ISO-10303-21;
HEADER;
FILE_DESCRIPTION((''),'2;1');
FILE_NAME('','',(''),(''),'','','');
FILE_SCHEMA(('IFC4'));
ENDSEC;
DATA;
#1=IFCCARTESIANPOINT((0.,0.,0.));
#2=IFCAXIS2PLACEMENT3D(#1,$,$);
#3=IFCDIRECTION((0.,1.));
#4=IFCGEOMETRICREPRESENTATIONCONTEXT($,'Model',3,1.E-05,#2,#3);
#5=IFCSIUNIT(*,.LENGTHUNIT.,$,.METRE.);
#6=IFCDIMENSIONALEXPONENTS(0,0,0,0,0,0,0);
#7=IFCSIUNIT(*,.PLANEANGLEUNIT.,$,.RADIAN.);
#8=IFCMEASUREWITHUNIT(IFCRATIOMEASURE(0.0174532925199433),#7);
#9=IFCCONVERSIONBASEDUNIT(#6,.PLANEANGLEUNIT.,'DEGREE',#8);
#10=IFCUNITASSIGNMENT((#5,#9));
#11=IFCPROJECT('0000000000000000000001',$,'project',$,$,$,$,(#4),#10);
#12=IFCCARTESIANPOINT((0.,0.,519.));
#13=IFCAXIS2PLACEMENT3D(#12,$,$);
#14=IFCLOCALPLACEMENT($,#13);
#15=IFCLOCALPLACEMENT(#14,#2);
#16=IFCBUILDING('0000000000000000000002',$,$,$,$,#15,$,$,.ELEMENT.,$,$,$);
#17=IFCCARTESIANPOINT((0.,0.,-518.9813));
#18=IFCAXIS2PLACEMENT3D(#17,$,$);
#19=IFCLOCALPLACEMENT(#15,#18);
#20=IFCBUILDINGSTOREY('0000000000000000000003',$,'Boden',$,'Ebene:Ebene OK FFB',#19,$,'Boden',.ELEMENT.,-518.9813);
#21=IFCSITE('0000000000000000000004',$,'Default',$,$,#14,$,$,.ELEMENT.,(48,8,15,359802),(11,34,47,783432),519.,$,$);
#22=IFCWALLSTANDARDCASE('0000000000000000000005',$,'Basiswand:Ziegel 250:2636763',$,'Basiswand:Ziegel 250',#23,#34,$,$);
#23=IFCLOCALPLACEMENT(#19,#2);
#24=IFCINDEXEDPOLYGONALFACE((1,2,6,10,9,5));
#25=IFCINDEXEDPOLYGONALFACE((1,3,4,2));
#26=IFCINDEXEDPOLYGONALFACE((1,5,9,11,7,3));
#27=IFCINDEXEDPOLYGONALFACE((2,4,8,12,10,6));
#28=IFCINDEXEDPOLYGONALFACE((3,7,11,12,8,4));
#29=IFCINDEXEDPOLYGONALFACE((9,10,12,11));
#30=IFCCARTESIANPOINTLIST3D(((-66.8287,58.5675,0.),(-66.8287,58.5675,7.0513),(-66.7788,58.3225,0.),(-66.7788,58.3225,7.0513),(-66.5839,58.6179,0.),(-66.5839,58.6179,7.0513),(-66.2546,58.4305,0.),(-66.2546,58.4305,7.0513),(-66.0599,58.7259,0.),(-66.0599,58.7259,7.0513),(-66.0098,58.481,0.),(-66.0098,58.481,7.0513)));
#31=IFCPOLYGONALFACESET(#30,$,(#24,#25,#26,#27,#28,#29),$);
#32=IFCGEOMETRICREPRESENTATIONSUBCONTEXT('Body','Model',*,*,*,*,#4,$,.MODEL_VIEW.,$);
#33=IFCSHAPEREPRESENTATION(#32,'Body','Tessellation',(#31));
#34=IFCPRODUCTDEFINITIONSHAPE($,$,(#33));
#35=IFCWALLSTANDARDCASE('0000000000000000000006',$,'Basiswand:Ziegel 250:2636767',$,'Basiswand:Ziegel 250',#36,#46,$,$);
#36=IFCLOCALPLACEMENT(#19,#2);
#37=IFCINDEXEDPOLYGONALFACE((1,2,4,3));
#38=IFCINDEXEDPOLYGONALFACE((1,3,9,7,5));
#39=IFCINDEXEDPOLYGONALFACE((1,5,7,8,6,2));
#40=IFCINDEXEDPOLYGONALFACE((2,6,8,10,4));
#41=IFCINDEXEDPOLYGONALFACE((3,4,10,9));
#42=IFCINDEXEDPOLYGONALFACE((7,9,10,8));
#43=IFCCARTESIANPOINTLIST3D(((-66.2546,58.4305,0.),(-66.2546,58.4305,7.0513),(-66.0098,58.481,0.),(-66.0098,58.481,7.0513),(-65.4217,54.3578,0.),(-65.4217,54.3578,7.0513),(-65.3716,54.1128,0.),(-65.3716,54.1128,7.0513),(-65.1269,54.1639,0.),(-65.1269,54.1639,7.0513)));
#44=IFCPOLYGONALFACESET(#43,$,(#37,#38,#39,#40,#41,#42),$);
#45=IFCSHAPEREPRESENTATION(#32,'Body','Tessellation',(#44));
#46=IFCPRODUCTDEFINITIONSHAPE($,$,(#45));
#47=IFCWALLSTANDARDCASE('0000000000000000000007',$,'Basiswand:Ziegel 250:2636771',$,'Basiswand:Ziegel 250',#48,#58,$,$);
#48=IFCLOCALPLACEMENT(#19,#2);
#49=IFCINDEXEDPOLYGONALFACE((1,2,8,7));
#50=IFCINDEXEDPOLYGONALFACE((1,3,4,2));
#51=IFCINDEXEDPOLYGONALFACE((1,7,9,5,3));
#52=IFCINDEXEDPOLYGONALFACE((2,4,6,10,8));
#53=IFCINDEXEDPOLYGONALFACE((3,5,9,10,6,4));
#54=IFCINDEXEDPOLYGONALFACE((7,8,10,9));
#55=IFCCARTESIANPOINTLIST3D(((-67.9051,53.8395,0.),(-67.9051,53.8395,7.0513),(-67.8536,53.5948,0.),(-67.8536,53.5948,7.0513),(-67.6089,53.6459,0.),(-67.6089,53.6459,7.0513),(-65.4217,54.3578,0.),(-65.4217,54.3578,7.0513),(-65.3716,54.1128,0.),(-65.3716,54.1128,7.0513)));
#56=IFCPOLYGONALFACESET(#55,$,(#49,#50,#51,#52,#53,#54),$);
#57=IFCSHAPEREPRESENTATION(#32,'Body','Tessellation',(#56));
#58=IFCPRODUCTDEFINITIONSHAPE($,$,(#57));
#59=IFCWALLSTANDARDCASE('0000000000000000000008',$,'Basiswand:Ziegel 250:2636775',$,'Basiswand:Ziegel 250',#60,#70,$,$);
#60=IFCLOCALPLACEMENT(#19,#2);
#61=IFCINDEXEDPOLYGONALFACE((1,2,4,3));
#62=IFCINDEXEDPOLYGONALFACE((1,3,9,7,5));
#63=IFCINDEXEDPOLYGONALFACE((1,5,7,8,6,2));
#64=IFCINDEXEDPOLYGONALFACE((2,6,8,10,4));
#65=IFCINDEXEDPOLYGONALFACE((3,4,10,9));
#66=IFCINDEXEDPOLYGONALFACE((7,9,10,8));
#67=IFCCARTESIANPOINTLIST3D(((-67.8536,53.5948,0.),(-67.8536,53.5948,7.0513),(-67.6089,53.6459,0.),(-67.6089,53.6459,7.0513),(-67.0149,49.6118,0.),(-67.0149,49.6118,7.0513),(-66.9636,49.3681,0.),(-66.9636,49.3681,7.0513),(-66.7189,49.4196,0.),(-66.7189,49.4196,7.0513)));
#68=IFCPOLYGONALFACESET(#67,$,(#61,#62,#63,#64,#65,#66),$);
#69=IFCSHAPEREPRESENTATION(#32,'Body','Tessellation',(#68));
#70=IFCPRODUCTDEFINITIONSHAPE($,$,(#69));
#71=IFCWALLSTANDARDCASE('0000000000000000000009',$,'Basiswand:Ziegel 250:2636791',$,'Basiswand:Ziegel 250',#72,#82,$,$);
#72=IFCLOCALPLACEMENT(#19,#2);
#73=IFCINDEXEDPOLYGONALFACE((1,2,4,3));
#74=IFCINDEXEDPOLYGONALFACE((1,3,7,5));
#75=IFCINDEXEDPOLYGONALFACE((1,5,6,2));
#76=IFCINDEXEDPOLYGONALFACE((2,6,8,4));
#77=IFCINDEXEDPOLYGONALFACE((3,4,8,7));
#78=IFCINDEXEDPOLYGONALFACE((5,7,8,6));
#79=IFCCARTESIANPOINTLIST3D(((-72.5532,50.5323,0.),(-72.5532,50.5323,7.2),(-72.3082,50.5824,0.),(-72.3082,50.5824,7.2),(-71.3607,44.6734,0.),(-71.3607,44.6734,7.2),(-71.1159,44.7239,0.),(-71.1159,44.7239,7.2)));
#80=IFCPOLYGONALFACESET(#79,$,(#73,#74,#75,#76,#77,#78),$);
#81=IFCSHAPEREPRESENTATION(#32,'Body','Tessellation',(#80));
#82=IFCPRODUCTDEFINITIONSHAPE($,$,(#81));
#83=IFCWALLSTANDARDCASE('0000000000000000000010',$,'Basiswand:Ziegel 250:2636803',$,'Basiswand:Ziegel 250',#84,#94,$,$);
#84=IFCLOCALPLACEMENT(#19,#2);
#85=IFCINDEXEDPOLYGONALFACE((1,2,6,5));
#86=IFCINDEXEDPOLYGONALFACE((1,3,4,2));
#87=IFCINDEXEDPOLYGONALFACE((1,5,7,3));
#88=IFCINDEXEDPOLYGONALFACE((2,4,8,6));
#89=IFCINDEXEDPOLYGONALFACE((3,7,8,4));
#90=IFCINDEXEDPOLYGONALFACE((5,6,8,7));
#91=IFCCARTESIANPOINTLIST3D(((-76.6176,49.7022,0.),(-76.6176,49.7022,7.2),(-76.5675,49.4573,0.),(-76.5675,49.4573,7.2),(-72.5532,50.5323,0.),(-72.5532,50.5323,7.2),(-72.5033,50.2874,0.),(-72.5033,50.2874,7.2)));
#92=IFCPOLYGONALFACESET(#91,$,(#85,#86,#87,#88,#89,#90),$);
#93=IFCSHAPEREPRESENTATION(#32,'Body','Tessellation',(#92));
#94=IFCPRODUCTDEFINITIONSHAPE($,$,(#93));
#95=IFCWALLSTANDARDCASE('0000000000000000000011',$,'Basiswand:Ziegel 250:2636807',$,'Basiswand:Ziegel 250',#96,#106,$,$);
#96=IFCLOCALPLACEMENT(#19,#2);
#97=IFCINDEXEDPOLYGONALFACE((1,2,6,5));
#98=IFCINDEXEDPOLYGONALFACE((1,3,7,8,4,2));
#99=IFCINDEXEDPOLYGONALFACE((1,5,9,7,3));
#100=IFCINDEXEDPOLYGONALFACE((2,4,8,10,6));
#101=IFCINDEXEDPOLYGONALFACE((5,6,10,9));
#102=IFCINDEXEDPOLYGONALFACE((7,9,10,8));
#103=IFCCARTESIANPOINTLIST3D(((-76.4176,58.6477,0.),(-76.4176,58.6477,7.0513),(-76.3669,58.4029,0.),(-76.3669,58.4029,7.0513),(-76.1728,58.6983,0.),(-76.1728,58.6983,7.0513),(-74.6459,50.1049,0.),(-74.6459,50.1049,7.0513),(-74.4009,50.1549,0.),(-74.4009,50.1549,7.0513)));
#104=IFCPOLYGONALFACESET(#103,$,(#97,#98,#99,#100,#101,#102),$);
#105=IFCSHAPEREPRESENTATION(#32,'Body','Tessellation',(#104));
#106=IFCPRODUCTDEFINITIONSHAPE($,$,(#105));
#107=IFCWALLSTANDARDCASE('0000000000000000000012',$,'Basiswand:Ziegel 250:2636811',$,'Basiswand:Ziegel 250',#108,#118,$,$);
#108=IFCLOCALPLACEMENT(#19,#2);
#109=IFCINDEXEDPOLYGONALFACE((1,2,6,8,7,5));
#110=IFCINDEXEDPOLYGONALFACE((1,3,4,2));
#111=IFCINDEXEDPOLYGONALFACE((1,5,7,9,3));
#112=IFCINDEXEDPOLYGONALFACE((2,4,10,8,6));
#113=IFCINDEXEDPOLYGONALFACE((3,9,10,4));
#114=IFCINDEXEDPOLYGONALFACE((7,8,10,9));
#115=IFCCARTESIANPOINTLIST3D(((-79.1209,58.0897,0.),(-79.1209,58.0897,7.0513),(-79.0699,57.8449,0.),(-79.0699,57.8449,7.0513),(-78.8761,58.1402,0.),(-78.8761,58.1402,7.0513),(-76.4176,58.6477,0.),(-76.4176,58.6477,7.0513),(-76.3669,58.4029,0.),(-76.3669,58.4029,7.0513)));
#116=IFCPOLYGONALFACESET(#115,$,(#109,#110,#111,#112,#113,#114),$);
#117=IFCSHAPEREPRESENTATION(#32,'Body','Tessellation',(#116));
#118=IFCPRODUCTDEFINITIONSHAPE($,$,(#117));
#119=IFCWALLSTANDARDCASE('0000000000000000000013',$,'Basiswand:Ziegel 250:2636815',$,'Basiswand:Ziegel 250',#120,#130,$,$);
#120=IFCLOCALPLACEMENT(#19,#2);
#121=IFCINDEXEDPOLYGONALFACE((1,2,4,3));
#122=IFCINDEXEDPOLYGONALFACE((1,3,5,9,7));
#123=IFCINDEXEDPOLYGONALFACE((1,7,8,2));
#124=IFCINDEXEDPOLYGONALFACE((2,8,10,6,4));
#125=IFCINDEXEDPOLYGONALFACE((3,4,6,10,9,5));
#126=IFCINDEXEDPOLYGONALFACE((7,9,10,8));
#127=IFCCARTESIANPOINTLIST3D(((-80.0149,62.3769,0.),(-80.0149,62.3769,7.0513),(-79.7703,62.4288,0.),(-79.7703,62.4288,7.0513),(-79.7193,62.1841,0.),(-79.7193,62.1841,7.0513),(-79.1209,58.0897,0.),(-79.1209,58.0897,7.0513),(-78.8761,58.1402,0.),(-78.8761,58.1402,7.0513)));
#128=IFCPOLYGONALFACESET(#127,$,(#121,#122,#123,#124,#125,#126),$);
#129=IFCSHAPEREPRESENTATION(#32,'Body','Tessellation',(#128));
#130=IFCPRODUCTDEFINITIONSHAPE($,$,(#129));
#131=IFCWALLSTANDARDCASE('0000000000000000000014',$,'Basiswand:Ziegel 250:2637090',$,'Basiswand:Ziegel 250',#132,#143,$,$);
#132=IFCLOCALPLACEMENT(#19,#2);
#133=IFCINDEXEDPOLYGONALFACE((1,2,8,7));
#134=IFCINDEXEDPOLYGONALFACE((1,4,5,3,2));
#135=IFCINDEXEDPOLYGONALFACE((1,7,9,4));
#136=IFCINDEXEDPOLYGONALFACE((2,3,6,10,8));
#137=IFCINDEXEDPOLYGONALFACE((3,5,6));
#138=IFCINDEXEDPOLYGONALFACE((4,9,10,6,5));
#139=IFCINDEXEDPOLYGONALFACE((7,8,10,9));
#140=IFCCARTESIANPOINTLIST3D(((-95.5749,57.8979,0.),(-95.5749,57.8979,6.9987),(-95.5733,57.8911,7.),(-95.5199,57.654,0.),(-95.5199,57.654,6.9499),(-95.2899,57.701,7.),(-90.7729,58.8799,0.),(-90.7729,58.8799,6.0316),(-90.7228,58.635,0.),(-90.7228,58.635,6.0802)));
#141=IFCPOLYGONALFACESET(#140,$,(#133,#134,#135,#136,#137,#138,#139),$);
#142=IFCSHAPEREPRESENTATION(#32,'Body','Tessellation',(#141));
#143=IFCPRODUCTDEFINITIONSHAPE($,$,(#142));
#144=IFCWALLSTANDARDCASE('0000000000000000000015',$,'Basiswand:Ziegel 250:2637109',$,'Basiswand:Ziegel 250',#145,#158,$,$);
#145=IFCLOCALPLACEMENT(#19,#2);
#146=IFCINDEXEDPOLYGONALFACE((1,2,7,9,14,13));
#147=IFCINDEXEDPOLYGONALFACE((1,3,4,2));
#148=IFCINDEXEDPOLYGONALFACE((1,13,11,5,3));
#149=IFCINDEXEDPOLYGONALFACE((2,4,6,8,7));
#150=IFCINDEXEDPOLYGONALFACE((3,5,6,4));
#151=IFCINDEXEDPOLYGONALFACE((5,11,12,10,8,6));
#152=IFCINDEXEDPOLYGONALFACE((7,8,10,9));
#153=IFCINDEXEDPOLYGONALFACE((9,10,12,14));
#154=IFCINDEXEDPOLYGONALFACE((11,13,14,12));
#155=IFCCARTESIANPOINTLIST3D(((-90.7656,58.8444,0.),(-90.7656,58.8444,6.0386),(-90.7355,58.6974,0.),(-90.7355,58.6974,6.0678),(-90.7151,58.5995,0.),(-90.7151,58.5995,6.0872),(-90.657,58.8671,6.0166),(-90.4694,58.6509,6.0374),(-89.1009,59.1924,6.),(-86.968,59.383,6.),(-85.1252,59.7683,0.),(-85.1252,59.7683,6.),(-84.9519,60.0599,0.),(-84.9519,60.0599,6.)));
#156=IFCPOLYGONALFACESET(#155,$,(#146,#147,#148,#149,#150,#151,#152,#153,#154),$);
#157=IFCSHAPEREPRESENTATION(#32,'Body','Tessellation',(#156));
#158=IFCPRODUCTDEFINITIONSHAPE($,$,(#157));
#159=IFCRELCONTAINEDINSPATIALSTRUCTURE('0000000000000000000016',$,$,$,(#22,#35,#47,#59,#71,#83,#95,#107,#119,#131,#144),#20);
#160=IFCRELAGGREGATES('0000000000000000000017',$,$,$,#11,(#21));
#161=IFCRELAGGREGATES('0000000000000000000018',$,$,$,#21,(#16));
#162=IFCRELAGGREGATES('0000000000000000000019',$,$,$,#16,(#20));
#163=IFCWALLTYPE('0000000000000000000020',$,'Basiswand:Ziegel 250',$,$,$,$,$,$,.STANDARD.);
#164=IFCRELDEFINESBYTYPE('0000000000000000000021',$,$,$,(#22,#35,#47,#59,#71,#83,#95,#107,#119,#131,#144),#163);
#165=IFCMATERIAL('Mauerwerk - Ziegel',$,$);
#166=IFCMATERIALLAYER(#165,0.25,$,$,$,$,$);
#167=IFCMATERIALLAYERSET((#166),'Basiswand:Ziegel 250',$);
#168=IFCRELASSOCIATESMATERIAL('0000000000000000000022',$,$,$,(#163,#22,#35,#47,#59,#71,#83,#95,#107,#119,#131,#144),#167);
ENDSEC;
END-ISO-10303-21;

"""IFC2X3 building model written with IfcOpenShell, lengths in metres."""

from ifc_helpers import new_model, entity, si_unit, converted_unit, direction, frame, origin, place, context, subcontext, project, spatial, polyline, outline, extrude, clip, bounded_halfspace, material, layer, layer_set, layer_usage, type_object, element, save


model = new_model("IFC2X3")

# Units and contexts
model_context = context("Model", 3, precision=1e-05, world=origin(), true_north=direction((0.0, 1.0)))
body_context = subcontext(model_context, "Body", "Model", "MODEL_VIEW")
ifc_project = project(units=[si_unit("LENGTHUNIT", "METRE"), converted_unit("PLANEANGLEUNIT", "DEGREE", entity("IfcRatioMeasure", 0.0174532925199433), si_unit("PLANEANGLEUNIT", "RADIAN"), dimensions=[0, 0, 0, 0, 0, 0, 0])], contexts=[model_context])

# Site, building, storey
site_placement = place(None, frame((0.0, 0.0, 519.0)))
site = spatial("IfcSite", under=ifc_project, at=site_placement, Name="Default", CompositionType="ELEMENT", RefLatitude=(48, 8, 15, 359802), RefLongitude=(11, 34, 47, 783432), RefElevation=519.0)
building_placement = place(site_placement, origin())
building = spatial("IfcBuilding", under=site, at=building_placement, CompositionType="ELEMENT")
storey_placement = place(building_placement, frame((0.0, 0.0, -518.9813)))
storey = spatial("IfcBuildingStorey", under=building, at=storey_placement, Name="Boden", ObjectType="Ebene:Ebene OK FFB", LongName="Boden", CompositionType="ELEMENT", Elevation=-518.9813)

# Walls
ifc_material = material(Name="Mauerwerk - Ziegel")
ifc_layer = layer(ifc_material, 0.25)
ifc_layer_set = layer_set([ifc_layer], Name="Basiswand:Ziegel 250")
ifc_layer_usage_1 = layer_usage(ifc_layer_set, "AXIS2", "NEGATIVE", 0.125)
wall_type = type_object("IfcWallType", Name="Basiswand:Ziegel 250", PredefinedType="STANDARD", material=ifc_layer_set)
wall_1_placement = place(storey_placement, frame((-66.804, 58.4449, 0.0), z_axis=(0.0, 0.0, 1.0), x_axis=(0.979414, 0.201864, 0.0)))
element("IfcWallStandardCase", 1, at=wall_1_placement, inside=storey, type_object=wall_type, material=ifc_layer_usage_1, Name="Basiswand:Ziegel 250:2636763", ObjectType="Basiswand:Ziegel 250", context=body_context, shape_type="SweptSolid", body=[
    extrude(outline(polyline([(0.7852, -0.125), (0.7856, 0.125), (0.2506, 0.125), (0.0006, 0.125), (0.0, -0.125), (0.5352, -0.125), (0.7852, -0.125)])), origin(), (0.0, 0.0, 1.0), 7.0513),
])
ifc_layer_usage_2 = layer_usage(ifc_layer_set, "AXIS2", "NEGATIVE", 0.125)
wall_2_placement = place(storey_placement, frame((-66.1322, 58.4559, 0.0), z_axis=(0.0, 0.0, 1.0), x_axis=(0.200368, -0.979721, 0.0)))
element("IfcWallStandardCase", 2, at=wall_2_placement, inside=storey, type_object=wall_type, material=ifc_layer_usage_2, Name="Basiswand:Ziegel 250:2636767", ObjectType="Basiswand:Ziegel 250", context=body_context, shape_type="SweptSolid", body=[
    extrude(outline(polyline([(4.4074, -0.125), (4.4064, 0.125), (0.0, 0.125), (0.0004, -0.125), (4.1574, -0.125), (4.4074, -0.125)])), origin(), (0.0, 0.0, 1.0), 7.0513),
])
ifc_layer_usage_3 = layer_usage(ifc_layer_set, "AXIS2", "NEGATIVE", 0.125)
wall_3_placement = place(storey_placement, frame((-65.3961, 54.2354, 0.0), z_axis=(0.0, 0.0, 1.0), x_axis=(-0.978908, -0.204301, 0.0)))
element("IfcWallStandardCase", 3, at=wall_3_placement, inside=storey, type_object=wall_type, material=ifc_layer_usage_3, Name="Basiswand:Ziegel 250:2636771", ObjectType="Basiswand:Ziegel 250", context=body_context, shape_type="SweptSolid", body=[
    extrude(outline(polyline([(2.5369, -0.125), (2.5365, 0.125), (2.2865, 0.125), (0.001, 0.125), (0.0, -0.125), (2.5369, -0.125)])), origin(), (0.0, 0.0, 1.0), 7.0513),
])
ifc_layer_usage_4 = layer_usage(ifc_layer_set, "AXIS2", "NEGATIVE", 0.125)
wall_4_placement = place(storey_placement, frame((-67.7313, 53.6206, 0.0), z_axis=(0.0, 0.0, 1.0), x_axis=(0.206048, -0.978542, 0.0)))
element("IfcWallStandardCase", 4, at=wall_4_placement, inside=storey, type_object=wall_type, material=ifc_layer_usage_4, Name="Basiswand:Ziegel 250:2636775", ObjectType="Basiswand:Ziegel 250", context=body_context, shape_type="SweptSolid", body=[
    extrude(outline(polyline([(4.3194, -0.125), (4.3194, 0.125), (0.0004, 0.125), (0.0, -0.125), (4.0704, -0.125), (4.3194, -0.125)])), origin(), (0.0, 0.0, 1.0), 7.0513),
])
ifc_layer_usage_5 = layer_usage(ifc_layer_set, "AXIS2", "NEGATIVE", 0.125)
wall_5_placement = place(storey_placement, frame((-72.4307, 50.5574, 0.0), z_axis=(0.0, 0.0, 1.0), x_axis=(0.199439, -0.97991, 0.0)))
element("IfcWallStandardCase", 5, at=wall_5_placement, inside=storey, type_object=wall_type, material=ifc_layer_usage_5, Name="Basiswand:Ziegel 250:2636791", ObjectType="Basiswand:Ziegel 250", context=body_context, shape_type="Clipping", body=[
    clip(extrude(outline(polyline([(5.9793, -0.125), (5.9786, 0.125), (2.1925, 0.125), (1.9425, 0.125), (0.0, 0.125), (0.0002, -0.125), (0.2502, -0.125), (5.7293, -0.125), (5.9793, -0.125)])), origin(), (0.0, 0.0, 1.0), 7.2), bounded_halfspace(frame((0.0002, -0.125, 7.2), z_axis=(0.0, 0.0, 1.0), x_axis=(-0.002767, 0.999996, 0.0)), False, frame((0.0002, -0.125, 7.2)), polyline([(0.0, 0.0), (0.25, 0.0), (5.7291, 0.0), (5.9791, 0.0), (5.9784, 0.25), (-0.0002, 0.25), (0.0, 0.0)]))),
])
ifc_layer_usage_6 = layer_usage(ifc_layer_set, "AXIS2", "NEGATIVE", 0.125)
wall_6_placement = place(storey_placement, frame((-76.5926, 49.5797, 0.0), z_axis=(0.0, 0.0, 1.0), x_axis=(0.979773, 0.200114, 0.0)))
element("IfcWallStandardCase", 6, at=wall_6_placement, inside=storey, type_object=wall_type, material=ifc_layer_usage_6, Name="Basiswand:Ziegel 250:2636803", ObjectType="Basiswand:Ziegel 250", context=body_context, shape_type="Clipping", body=[
    clip(extrude(outline(polyline([(4.1481, -0.125), (4.1483, 0.125), (2.2624, 0.125), (2.0124, 0.125), (0.0, 0.125), (0.0, -0.125), (4.1481, -0.125)])), origin(), (0.0, 0.0, 1.0), 7.2), bounded_halfspace(frame((0.0, -0.125, 7.2), z_axis=(0.0, 0.0, 1.0), x_axis=(0.999998, 0.002078, 0.0)), False, frame((0.0, -0.125, 7.2)), polyline([(0.0, 0.0), (4.1481, 0.0), (4.1483, 0.25), (0.0, 0.25), (0.0, 0.0)]))),
])
ifc_layer_usage_7 = layer_usage(ifc_layer_set, "AXIS2", "NEGATIVE", 0.125)
wall_7_placement = place(storey_placement, frame((-74.5233, 50.1296, 0.0), z_axis=(0.0, 0.0, 1.0), x_axis=(-0.203078, 0.979163, 0.0)))
element("IfcWallStandardCase", 7, at=wall_7_placement, inside=storey, type_object=wall_type, material=ifc_layer_usage_7, Name="Basiswand:Ziegel 250:2636807", ObjectType="Basiswand:Ziegel 250", context=body_context, shape_type="SweptSolid", body=[
    extrude(outline(polyline([(8.7251, -0.125), (8.7253, 0.125), (8.4753, 0.125), (0.0008, 0.125), (0.0, -0.125), (8.7251, -0.125)])), origin(), (0.0, 0.0, 1.0), 7.0513),
])
ifc_layer_usage_8 = layer_usage(ifc_layer_set, "AXIS2", "NEGATIVE", 0.125)
wall_8_placement = place(storey_placement, frame((-76.3921, 58.5253, 0.0), z_axis=(0.0, 0.0, 1.0), x_axis=(-0.97935, -0.202174, 0.0)))
element("IfcWallStandardCase", 8, at=wall_8_placement, inside=storey, type_object=wall_type, material=ifc_layer_usage_8, Name="Basiswand:Ziegel 250:2636811", ObjectType="Basiswand:Ziegel 250", context=body_context, shape_type="SweptSolid", body=[
    extrude(outline(polyline([(2.7605, -0.125), (2.76, 0.125), (0.0, 0.125), (0.0002, -0.125), (2.5105, -0.125), (2.7605, -0.125)])), origin(), (0.0, 0.0, 1.0), 7.0513),
])
ifc_layer_usage_9 = layer_usage(ifc_layer_set, "AXIS2", "NEGATIVE", 0.125)
wall_9_placement = place(storey_placement, frame((-78.9984, 58.1147, 0.0), z_axis=(0.0, 0.0, 1.0), x_axis=(-0.204127, 0.978944, 0.0)))
element("IfcWallStandardCase", 9, at=wall_9_placement, inside=storey, type_object=wall_type, material=ifc_layer_usage_9, Name="Basiswand:Ziegel 250:2636815", ObjectType="Basiswand:Ziegel 250", context=body_context, shape_type="SweptSolid", body=[
    extrude(outline(polyline([(4.3809, -0.125), (4.38, 0.125), (0.0005, 0.125), (0.0, -0.125), (4.1309, -0.125), (4.3809, -0.125)])), origin(), (0.0, 0.0, 1.0), 7.0513),
])
ifc_layer_usage_10 = layer_usage(ifc_layer_set, "AXIS2", "NEGATIVE", 0.125)
wall_10_placement = place(storey_placement, frame((-95.5498, 57.7755, 0.0), z_axis=(0.0, 0.0, 1.0), x_axis=(0.979724, 0.200352, 0.0)))
element("IfcWallStandardCase", 10, at=wall_10_placement, inside=storey, type_object=wall_type, material=ifc_layer_usage_10, Name="Basiswand:Ziegel 250:2637090", ObjectType="Basiswand:Ziegel 250", context=body_context, shape_type="Clipping", body=[
    clip(clip(extrude(outline(polyline([(4.9014, -0.125), (4.9014, -0.0613), (4.9014, 0.0887), (4.9014, 0.125), (0.0, 0.125), (0.005, -0.125), (0.2551, -0.125), (4.9014, -0.125)])), origin(), (0.0, 0.0, 1.0), 7.0), bounded_halfspace(frame((0.005, -0.125, 6.9499), z_axis=(-0.204536, -0.201725, 0.957848), x_axis=(0.019626, -0.979183, -0.202027)), False, frame((0.005, -0.125, 6.9499)), polyline([(0.0, 0.0), (0.2348, 0.0), (-0.0049, 0.243), (0.0, 0.0)]))), bounded_halfspace(frame((0.2398, -0.125, 7.0), z_axis=(0.190146, 0.187532, 0.963679), x_axis=(-0.981318, 0.006976, 0.192269)), False, frame((0.2398, -0.125, 7.0)), polyline([(0.0, 0.0), (0.0153, 0.0), (4.6616, 0.0), (4.6616, 0.0637), (4.6616, 0.2137), (4.6616, 0.25), (-0.2398, 0.25), (-0.2396, 0.243), (0.0, 0.0)]))),
])
ifc_layer_usage_11 = layer_usage(ifc_layer_set, "AXIS2", "NEGATIVE", 0.125)
wall_11_placement = place(storey_placement, frame((-90.7407, 58.7219, 0.0), z_axis=(0.0, 0.0, 1.0), x_axis=(0.978834, 0.204656, 0.0)))
element("IfcWallStandardCase", 11, at=wall_11_placement, inside=storey, type_object=wall_type, material=ifc_layer_usage_11, Name="Basiswand:Ziegel 250:2637109", ObjectType="Basiswand:Ziegel 250", context=body_context, shape_type="Clipping", body=[
    clip(clip(clip(clip(extrude(outline(polyline([(5.7108, -0.125), (5.9401, 0.125), (0.0007, 0.125), (0.0, -0.025), (0.0, -0.125), (5.7108, -0.125)])), origin(), (0.0, 0.0, 1.0), 6.0872), bounded_halfspace(frame((5.7108, -0.125, 6.0), z_axis=(0.0, 0.0, 1.0), x_axis=(0.663987, 0.747744, 0.0)), False, frame((5.7108, -0.125, 6.0)), polyline([(0.0, 0.0), (0.2293, 0.25), (-4.0094, 0.25), (-1.8827, 0.0), (0.0, 0.0)]))), bounded_halfspace(frame((0.251, -0.125, 6.0374), z_axis=(0.010425, 0.08868, 0.996006), x_axis=(-0.993161, 0.116749, 0.0)), False, frame((0.251, -0.125, 6.0374)), polyline([(0.0, 0.0), (3.5771, 0.0), (1.4504, 0.25), (-0.1394, 0.25), (0.0, 0.0)]))), bounded_halfspace(frame((0.0, -0.125, 6.0872), z_axis=(0.190968, 0.186695, 0.963679), x_axis=(-0.981277, 0.011289, 0.192269)), False, frame((0.0, -0.125, 6.0872)), polyline([(0.0, 0.0), (0.251, 0.0), (0.1116, 0.25), (0.0007, 0.25), (0.0, 0.1), (0.0, 0.0)]))), bounded_halfspace(frame((0.0007, 0.125, 6.0386), z_axis=(0.99999, -0.004395, 0.0), x_axis=(0.004395, 0.99999, 0.0)), True, frame((0.0007, 0.125, 6.0386), z_axis=(0.99999, -0.004395, 0.0), x_axis=(0.004395, 0.99999, 0.0)), polyline([(0.0, 0.0), (-0.15, 0.0292), (-0.15, -6.0386), (0.0, -6.0386), (0.0, 0.0)]))),
])

save(model, "model.ifc")
